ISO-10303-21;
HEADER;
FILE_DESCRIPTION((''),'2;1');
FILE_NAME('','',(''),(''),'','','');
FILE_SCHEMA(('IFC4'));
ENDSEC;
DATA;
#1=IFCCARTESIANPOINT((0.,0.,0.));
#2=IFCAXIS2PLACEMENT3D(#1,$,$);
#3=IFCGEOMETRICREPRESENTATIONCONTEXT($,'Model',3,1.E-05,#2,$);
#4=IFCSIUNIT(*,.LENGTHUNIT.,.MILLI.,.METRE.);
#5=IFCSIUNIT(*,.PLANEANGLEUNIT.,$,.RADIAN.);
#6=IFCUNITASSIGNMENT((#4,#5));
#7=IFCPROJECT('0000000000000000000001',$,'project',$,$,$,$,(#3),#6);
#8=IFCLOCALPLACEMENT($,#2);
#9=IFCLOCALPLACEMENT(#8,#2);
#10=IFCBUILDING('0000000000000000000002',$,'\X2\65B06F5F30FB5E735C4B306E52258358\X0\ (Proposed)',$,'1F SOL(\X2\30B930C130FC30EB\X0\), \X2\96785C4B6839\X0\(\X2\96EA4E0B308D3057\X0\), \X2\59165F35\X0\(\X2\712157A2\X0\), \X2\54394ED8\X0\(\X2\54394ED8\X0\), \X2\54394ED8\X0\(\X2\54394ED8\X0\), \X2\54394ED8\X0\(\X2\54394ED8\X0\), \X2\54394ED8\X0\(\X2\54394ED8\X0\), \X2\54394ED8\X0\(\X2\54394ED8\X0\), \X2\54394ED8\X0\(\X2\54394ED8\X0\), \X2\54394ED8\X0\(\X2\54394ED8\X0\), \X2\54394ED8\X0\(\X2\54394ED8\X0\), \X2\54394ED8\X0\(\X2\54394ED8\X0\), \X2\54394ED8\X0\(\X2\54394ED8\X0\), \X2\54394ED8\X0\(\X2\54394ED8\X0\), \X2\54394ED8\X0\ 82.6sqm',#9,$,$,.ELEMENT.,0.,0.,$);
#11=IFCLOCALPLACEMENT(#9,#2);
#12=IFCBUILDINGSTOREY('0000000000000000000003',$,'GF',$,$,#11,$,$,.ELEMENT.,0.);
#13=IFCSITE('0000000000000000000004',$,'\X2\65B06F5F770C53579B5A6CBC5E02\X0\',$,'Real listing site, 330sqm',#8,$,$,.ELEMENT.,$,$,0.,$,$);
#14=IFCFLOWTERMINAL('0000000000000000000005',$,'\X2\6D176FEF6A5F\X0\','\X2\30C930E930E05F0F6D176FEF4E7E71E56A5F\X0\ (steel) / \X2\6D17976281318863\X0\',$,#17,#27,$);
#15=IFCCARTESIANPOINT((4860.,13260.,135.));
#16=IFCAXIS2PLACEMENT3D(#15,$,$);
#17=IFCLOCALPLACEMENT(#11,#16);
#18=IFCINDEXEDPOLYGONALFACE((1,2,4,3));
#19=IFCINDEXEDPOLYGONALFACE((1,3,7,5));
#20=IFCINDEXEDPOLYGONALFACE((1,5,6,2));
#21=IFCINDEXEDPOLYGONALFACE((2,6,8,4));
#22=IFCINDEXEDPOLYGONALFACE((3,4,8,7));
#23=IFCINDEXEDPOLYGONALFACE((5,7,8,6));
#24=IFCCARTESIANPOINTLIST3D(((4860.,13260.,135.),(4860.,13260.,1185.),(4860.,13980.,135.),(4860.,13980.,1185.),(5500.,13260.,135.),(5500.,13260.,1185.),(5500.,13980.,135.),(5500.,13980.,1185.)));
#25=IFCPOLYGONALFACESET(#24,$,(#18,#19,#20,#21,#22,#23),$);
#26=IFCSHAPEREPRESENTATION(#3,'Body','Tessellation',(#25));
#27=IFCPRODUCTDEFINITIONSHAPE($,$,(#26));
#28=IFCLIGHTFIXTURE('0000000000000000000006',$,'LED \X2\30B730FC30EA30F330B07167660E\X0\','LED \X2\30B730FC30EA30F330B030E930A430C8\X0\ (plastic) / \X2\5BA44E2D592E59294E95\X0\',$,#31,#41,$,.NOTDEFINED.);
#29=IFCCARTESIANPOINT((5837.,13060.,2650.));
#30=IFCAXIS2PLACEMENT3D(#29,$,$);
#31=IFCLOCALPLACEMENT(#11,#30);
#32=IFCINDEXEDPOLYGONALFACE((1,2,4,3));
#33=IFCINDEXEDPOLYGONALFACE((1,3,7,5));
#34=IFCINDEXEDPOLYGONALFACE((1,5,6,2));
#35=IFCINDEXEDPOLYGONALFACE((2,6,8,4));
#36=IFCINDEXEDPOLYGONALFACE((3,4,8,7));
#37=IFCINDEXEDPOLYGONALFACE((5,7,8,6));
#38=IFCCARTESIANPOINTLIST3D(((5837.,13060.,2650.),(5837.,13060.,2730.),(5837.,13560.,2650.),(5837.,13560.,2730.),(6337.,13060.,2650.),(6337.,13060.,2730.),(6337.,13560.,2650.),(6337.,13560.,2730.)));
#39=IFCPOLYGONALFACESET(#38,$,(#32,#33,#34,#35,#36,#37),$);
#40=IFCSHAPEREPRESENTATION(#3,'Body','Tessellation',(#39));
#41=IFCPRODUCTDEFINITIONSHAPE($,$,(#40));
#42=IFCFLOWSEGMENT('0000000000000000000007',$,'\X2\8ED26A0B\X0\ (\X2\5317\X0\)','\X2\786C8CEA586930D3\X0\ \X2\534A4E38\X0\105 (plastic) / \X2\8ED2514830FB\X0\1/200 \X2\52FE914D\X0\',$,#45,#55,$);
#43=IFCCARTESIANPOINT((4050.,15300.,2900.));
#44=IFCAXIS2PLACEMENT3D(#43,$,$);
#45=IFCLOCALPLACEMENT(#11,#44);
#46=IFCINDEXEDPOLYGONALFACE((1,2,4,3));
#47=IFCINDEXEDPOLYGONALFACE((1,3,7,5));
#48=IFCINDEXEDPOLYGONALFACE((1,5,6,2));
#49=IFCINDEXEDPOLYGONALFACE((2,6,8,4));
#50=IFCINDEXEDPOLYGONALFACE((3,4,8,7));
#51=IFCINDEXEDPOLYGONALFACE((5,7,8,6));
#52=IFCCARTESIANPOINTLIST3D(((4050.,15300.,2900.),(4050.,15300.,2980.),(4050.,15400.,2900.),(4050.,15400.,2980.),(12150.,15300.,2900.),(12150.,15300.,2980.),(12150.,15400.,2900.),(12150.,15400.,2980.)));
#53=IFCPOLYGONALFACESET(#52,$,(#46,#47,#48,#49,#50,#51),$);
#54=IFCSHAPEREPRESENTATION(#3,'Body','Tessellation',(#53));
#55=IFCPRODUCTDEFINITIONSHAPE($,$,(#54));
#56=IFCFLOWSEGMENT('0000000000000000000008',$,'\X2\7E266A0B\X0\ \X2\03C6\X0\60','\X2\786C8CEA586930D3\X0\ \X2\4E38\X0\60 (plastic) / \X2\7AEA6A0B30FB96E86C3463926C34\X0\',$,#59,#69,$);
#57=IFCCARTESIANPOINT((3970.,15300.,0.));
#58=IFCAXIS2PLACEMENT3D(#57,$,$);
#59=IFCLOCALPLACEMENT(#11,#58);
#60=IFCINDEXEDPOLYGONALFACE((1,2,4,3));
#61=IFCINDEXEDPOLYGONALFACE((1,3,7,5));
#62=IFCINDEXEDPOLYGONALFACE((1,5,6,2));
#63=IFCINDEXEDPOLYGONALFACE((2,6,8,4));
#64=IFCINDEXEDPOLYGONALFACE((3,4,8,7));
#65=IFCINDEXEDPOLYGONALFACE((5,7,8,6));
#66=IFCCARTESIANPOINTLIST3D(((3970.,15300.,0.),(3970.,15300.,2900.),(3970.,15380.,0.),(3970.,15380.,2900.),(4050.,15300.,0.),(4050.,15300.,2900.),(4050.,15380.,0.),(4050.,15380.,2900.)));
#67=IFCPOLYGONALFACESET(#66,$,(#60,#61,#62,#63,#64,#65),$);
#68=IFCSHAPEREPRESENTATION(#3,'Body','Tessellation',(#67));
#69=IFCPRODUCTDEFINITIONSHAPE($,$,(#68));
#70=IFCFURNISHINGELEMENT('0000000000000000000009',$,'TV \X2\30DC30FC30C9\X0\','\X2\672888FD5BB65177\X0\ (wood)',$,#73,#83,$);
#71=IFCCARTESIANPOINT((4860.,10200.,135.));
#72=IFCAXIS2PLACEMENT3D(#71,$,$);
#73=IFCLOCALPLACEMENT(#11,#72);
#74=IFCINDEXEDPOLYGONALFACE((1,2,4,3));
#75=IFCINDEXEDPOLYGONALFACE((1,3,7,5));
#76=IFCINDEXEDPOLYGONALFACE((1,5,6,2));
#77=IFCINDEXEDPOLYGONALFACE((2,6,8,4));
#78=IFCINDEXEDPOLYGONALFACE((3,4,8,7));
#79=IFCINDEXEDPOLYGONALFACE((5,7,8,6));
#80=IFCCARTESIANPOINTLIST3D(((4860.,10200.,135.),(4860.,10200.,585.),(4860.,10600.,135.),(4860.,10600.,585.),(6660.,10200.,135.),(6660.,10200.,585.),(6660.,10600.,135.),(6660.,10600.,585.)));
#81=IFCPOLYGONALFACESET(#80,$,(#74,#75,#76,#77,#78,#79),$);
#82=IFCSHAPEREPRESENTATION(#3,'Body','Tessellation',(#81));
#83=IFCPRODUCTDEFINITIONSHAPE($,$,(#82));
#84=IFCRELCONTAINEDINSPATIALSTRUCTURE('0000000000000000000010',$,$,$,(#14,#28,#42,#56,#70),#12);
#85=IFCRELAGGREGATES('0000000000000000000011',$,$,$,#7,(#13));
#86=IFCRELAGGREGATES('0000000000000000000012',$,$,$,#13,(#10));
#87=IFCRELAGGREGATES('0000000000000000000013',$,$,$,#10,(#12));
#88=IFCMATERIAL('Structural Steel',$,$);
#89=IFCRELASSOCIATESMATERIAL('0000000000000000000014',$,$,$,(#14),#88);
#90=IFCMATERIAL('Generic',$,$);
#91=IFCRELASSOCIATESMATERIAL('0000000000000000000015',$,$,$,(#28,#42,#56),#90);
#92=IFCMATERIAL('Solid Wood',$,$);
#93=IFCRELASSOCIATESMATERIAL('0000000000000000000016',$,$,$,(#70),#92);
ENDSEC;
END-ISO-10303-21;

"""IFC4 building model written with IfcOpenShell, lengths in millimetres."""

from ifc_helpers import new_model, si_unit, frame, frame_2d, origin, place, context, project, spatial, rectangle, extrude, material, element, save


model = new_model("IFC4")

# Units and contexts
model_context = context("Model", 3, precision=1e-05, world=origin())
ifc_project = project(units=[si_unit("LENGTHUNIT", "METRE", prefix="MILLI"), si_unit("PLANEANGLEUNIT", "RADIAN")], contexts=[model_context])

# Site, building, storey
site_placement = place(None, origin())
site = spatial("IfcSite", under=ifc_project, at=site_placement, Name="新潟県南魚沼市", ObjectType="Real listing site, 330sqm", CompositionType="ELEMENT", RefElevation=0.0)
building_placement = place(site_placement, origin())
building = spatial("IfcBuilding", under=site, at=building_placement, Name="新潟・平屋の別荘 (Proposed)", ObjectType="1F SOL(スチール), 陸屋根(雪下ろし), 外張(無垢), 吹付(吹付), 吹付(吹付), 吹付(吹付), 吹付(吹付), 吹付(吹付), 吹付(吹付), 吹付(吹付), 吹付(吹付), 吹付(吹付), 吹付(吹付), 吹付(吹付), 吹付 82.6sqm", CompositionType="ELEMENT", ElevationOfRefHeight=0.0, ElevationOfTerrain=0.0)
storey_placement = place(building_placement, origin())
storey = spatial("IfcBuildingStorey", under=building, at=storey_placement, Name="GF", CompositionType="ELEMENT", Elevation=0.0)

# Shared definitions
ifc_material_1 = material(Name="Solid Wood")

# Shared definitions
ifc_material_2 = material(Name="Generic")

# Shared definitions
ifc_material_3 = material(Name="Structural Steel")

# Flow terminal
flow_terminal_placement = place(storey_placement, frame((4860.0, 13260.0, 135.0)))
element("IfcFlowTerminal", 1, at=flow_terminal_placement, inside=storey, material=ifc_material_3, Name="洗濯機", Description="ドラム式洗濯乾燥機 (steel) / 洗面脱衣", context=model_context, shape_type="SweptSolid", body=[
    extrude(rectangle(XDim=640.0, YDim=720.0, at=frame_2d((320.0, 360.0))), frame((4860.0, 13260.0, 135.0)), (0.0, 0.0, 1.0), 1050.0),
])

# Light fixture
light_fixture_placement = place(storey_placement, frame((5837.0, 13060.0, 2650.0)))
element("IfcLightFixture", 2, at=light_fixture_placement, inside=storey, material=ifc_material_2, Name="LED シーリング照明", Description="LED シーリングライト (plastic) / 室中央天井", PredefinedType="NOTDEFINED", context=model_context, shape_type="SweptSolid", body=[
    extrude(rectangle(XDim=500.0, YDim=500.0, at=frame_2d((250.0, 250.0))), frame((5837.0, 13060.0, 2650.0)), (0.0, 0.0, 1.0), 80.0),
])

# Flow segments
flow_segment_1_placement = place(storey_placement, frame((4050.0, 15300.0, 2900.0)))
element("IfcFlowSegment", 3, at=flow_segment_1_placement, inside=storey, material=ifc_material_2, Name="軒樋 (北)", Description="硬質塩ビ 半丸105 (plastic) / 軒先・1/200 勾配", context=model_context, shape_type="SweptSolid", body=[
    extrude(rectangle(XDim=8100.0, YDim=100.0, at=frame_2d((4050.0, 50.0))), frame((4050.0, 15300.0, 2900.0)), (0.0, 0.0, 1.0), 80.0),
])
flow_segment_2_placement = place(storey_placement, frame((3970.0, 15300.0, 0.0)))
element("IfcFlowSegment", 4, at=flow_segment_2_placement, inside=storey, material=ifc_material_2, Name="縦樋 φ60", Description="硬質塩ビ 丸60 (plastic) / 竪樋・雨水排水", context=model_context, shape_type="SweptSolid", body=[
    extrude(rectangle(XDim=80.0, YDim=80.0, at=frame_2d((40.0, 40.0))), frame((3970.0, 15300.0, 0.0)), (0.0, 0.0, 1.0), 2900.0),
])

# Furnishing element
furnishing_placement = place(storey_placement, frame((4860.0, 10200.0, 135.0)))
element("IfcFurnishingElement", 5, at=furnishing_placement, inside=storey, material=ifc_material_1, Name="TV ボード", Description="木製家具 (wood)", context=model_context, shape_type="SweptSolid", body=[
    extrude(rectangle(XDim=1800.0, YDim=400.0, at=frame_2d((900.0, 200.0))), frame((4860.0, 10200.0, 135.0)), (0.0, 0.0, 1.0), 450.0),
])

save(model, "model.ifc")
